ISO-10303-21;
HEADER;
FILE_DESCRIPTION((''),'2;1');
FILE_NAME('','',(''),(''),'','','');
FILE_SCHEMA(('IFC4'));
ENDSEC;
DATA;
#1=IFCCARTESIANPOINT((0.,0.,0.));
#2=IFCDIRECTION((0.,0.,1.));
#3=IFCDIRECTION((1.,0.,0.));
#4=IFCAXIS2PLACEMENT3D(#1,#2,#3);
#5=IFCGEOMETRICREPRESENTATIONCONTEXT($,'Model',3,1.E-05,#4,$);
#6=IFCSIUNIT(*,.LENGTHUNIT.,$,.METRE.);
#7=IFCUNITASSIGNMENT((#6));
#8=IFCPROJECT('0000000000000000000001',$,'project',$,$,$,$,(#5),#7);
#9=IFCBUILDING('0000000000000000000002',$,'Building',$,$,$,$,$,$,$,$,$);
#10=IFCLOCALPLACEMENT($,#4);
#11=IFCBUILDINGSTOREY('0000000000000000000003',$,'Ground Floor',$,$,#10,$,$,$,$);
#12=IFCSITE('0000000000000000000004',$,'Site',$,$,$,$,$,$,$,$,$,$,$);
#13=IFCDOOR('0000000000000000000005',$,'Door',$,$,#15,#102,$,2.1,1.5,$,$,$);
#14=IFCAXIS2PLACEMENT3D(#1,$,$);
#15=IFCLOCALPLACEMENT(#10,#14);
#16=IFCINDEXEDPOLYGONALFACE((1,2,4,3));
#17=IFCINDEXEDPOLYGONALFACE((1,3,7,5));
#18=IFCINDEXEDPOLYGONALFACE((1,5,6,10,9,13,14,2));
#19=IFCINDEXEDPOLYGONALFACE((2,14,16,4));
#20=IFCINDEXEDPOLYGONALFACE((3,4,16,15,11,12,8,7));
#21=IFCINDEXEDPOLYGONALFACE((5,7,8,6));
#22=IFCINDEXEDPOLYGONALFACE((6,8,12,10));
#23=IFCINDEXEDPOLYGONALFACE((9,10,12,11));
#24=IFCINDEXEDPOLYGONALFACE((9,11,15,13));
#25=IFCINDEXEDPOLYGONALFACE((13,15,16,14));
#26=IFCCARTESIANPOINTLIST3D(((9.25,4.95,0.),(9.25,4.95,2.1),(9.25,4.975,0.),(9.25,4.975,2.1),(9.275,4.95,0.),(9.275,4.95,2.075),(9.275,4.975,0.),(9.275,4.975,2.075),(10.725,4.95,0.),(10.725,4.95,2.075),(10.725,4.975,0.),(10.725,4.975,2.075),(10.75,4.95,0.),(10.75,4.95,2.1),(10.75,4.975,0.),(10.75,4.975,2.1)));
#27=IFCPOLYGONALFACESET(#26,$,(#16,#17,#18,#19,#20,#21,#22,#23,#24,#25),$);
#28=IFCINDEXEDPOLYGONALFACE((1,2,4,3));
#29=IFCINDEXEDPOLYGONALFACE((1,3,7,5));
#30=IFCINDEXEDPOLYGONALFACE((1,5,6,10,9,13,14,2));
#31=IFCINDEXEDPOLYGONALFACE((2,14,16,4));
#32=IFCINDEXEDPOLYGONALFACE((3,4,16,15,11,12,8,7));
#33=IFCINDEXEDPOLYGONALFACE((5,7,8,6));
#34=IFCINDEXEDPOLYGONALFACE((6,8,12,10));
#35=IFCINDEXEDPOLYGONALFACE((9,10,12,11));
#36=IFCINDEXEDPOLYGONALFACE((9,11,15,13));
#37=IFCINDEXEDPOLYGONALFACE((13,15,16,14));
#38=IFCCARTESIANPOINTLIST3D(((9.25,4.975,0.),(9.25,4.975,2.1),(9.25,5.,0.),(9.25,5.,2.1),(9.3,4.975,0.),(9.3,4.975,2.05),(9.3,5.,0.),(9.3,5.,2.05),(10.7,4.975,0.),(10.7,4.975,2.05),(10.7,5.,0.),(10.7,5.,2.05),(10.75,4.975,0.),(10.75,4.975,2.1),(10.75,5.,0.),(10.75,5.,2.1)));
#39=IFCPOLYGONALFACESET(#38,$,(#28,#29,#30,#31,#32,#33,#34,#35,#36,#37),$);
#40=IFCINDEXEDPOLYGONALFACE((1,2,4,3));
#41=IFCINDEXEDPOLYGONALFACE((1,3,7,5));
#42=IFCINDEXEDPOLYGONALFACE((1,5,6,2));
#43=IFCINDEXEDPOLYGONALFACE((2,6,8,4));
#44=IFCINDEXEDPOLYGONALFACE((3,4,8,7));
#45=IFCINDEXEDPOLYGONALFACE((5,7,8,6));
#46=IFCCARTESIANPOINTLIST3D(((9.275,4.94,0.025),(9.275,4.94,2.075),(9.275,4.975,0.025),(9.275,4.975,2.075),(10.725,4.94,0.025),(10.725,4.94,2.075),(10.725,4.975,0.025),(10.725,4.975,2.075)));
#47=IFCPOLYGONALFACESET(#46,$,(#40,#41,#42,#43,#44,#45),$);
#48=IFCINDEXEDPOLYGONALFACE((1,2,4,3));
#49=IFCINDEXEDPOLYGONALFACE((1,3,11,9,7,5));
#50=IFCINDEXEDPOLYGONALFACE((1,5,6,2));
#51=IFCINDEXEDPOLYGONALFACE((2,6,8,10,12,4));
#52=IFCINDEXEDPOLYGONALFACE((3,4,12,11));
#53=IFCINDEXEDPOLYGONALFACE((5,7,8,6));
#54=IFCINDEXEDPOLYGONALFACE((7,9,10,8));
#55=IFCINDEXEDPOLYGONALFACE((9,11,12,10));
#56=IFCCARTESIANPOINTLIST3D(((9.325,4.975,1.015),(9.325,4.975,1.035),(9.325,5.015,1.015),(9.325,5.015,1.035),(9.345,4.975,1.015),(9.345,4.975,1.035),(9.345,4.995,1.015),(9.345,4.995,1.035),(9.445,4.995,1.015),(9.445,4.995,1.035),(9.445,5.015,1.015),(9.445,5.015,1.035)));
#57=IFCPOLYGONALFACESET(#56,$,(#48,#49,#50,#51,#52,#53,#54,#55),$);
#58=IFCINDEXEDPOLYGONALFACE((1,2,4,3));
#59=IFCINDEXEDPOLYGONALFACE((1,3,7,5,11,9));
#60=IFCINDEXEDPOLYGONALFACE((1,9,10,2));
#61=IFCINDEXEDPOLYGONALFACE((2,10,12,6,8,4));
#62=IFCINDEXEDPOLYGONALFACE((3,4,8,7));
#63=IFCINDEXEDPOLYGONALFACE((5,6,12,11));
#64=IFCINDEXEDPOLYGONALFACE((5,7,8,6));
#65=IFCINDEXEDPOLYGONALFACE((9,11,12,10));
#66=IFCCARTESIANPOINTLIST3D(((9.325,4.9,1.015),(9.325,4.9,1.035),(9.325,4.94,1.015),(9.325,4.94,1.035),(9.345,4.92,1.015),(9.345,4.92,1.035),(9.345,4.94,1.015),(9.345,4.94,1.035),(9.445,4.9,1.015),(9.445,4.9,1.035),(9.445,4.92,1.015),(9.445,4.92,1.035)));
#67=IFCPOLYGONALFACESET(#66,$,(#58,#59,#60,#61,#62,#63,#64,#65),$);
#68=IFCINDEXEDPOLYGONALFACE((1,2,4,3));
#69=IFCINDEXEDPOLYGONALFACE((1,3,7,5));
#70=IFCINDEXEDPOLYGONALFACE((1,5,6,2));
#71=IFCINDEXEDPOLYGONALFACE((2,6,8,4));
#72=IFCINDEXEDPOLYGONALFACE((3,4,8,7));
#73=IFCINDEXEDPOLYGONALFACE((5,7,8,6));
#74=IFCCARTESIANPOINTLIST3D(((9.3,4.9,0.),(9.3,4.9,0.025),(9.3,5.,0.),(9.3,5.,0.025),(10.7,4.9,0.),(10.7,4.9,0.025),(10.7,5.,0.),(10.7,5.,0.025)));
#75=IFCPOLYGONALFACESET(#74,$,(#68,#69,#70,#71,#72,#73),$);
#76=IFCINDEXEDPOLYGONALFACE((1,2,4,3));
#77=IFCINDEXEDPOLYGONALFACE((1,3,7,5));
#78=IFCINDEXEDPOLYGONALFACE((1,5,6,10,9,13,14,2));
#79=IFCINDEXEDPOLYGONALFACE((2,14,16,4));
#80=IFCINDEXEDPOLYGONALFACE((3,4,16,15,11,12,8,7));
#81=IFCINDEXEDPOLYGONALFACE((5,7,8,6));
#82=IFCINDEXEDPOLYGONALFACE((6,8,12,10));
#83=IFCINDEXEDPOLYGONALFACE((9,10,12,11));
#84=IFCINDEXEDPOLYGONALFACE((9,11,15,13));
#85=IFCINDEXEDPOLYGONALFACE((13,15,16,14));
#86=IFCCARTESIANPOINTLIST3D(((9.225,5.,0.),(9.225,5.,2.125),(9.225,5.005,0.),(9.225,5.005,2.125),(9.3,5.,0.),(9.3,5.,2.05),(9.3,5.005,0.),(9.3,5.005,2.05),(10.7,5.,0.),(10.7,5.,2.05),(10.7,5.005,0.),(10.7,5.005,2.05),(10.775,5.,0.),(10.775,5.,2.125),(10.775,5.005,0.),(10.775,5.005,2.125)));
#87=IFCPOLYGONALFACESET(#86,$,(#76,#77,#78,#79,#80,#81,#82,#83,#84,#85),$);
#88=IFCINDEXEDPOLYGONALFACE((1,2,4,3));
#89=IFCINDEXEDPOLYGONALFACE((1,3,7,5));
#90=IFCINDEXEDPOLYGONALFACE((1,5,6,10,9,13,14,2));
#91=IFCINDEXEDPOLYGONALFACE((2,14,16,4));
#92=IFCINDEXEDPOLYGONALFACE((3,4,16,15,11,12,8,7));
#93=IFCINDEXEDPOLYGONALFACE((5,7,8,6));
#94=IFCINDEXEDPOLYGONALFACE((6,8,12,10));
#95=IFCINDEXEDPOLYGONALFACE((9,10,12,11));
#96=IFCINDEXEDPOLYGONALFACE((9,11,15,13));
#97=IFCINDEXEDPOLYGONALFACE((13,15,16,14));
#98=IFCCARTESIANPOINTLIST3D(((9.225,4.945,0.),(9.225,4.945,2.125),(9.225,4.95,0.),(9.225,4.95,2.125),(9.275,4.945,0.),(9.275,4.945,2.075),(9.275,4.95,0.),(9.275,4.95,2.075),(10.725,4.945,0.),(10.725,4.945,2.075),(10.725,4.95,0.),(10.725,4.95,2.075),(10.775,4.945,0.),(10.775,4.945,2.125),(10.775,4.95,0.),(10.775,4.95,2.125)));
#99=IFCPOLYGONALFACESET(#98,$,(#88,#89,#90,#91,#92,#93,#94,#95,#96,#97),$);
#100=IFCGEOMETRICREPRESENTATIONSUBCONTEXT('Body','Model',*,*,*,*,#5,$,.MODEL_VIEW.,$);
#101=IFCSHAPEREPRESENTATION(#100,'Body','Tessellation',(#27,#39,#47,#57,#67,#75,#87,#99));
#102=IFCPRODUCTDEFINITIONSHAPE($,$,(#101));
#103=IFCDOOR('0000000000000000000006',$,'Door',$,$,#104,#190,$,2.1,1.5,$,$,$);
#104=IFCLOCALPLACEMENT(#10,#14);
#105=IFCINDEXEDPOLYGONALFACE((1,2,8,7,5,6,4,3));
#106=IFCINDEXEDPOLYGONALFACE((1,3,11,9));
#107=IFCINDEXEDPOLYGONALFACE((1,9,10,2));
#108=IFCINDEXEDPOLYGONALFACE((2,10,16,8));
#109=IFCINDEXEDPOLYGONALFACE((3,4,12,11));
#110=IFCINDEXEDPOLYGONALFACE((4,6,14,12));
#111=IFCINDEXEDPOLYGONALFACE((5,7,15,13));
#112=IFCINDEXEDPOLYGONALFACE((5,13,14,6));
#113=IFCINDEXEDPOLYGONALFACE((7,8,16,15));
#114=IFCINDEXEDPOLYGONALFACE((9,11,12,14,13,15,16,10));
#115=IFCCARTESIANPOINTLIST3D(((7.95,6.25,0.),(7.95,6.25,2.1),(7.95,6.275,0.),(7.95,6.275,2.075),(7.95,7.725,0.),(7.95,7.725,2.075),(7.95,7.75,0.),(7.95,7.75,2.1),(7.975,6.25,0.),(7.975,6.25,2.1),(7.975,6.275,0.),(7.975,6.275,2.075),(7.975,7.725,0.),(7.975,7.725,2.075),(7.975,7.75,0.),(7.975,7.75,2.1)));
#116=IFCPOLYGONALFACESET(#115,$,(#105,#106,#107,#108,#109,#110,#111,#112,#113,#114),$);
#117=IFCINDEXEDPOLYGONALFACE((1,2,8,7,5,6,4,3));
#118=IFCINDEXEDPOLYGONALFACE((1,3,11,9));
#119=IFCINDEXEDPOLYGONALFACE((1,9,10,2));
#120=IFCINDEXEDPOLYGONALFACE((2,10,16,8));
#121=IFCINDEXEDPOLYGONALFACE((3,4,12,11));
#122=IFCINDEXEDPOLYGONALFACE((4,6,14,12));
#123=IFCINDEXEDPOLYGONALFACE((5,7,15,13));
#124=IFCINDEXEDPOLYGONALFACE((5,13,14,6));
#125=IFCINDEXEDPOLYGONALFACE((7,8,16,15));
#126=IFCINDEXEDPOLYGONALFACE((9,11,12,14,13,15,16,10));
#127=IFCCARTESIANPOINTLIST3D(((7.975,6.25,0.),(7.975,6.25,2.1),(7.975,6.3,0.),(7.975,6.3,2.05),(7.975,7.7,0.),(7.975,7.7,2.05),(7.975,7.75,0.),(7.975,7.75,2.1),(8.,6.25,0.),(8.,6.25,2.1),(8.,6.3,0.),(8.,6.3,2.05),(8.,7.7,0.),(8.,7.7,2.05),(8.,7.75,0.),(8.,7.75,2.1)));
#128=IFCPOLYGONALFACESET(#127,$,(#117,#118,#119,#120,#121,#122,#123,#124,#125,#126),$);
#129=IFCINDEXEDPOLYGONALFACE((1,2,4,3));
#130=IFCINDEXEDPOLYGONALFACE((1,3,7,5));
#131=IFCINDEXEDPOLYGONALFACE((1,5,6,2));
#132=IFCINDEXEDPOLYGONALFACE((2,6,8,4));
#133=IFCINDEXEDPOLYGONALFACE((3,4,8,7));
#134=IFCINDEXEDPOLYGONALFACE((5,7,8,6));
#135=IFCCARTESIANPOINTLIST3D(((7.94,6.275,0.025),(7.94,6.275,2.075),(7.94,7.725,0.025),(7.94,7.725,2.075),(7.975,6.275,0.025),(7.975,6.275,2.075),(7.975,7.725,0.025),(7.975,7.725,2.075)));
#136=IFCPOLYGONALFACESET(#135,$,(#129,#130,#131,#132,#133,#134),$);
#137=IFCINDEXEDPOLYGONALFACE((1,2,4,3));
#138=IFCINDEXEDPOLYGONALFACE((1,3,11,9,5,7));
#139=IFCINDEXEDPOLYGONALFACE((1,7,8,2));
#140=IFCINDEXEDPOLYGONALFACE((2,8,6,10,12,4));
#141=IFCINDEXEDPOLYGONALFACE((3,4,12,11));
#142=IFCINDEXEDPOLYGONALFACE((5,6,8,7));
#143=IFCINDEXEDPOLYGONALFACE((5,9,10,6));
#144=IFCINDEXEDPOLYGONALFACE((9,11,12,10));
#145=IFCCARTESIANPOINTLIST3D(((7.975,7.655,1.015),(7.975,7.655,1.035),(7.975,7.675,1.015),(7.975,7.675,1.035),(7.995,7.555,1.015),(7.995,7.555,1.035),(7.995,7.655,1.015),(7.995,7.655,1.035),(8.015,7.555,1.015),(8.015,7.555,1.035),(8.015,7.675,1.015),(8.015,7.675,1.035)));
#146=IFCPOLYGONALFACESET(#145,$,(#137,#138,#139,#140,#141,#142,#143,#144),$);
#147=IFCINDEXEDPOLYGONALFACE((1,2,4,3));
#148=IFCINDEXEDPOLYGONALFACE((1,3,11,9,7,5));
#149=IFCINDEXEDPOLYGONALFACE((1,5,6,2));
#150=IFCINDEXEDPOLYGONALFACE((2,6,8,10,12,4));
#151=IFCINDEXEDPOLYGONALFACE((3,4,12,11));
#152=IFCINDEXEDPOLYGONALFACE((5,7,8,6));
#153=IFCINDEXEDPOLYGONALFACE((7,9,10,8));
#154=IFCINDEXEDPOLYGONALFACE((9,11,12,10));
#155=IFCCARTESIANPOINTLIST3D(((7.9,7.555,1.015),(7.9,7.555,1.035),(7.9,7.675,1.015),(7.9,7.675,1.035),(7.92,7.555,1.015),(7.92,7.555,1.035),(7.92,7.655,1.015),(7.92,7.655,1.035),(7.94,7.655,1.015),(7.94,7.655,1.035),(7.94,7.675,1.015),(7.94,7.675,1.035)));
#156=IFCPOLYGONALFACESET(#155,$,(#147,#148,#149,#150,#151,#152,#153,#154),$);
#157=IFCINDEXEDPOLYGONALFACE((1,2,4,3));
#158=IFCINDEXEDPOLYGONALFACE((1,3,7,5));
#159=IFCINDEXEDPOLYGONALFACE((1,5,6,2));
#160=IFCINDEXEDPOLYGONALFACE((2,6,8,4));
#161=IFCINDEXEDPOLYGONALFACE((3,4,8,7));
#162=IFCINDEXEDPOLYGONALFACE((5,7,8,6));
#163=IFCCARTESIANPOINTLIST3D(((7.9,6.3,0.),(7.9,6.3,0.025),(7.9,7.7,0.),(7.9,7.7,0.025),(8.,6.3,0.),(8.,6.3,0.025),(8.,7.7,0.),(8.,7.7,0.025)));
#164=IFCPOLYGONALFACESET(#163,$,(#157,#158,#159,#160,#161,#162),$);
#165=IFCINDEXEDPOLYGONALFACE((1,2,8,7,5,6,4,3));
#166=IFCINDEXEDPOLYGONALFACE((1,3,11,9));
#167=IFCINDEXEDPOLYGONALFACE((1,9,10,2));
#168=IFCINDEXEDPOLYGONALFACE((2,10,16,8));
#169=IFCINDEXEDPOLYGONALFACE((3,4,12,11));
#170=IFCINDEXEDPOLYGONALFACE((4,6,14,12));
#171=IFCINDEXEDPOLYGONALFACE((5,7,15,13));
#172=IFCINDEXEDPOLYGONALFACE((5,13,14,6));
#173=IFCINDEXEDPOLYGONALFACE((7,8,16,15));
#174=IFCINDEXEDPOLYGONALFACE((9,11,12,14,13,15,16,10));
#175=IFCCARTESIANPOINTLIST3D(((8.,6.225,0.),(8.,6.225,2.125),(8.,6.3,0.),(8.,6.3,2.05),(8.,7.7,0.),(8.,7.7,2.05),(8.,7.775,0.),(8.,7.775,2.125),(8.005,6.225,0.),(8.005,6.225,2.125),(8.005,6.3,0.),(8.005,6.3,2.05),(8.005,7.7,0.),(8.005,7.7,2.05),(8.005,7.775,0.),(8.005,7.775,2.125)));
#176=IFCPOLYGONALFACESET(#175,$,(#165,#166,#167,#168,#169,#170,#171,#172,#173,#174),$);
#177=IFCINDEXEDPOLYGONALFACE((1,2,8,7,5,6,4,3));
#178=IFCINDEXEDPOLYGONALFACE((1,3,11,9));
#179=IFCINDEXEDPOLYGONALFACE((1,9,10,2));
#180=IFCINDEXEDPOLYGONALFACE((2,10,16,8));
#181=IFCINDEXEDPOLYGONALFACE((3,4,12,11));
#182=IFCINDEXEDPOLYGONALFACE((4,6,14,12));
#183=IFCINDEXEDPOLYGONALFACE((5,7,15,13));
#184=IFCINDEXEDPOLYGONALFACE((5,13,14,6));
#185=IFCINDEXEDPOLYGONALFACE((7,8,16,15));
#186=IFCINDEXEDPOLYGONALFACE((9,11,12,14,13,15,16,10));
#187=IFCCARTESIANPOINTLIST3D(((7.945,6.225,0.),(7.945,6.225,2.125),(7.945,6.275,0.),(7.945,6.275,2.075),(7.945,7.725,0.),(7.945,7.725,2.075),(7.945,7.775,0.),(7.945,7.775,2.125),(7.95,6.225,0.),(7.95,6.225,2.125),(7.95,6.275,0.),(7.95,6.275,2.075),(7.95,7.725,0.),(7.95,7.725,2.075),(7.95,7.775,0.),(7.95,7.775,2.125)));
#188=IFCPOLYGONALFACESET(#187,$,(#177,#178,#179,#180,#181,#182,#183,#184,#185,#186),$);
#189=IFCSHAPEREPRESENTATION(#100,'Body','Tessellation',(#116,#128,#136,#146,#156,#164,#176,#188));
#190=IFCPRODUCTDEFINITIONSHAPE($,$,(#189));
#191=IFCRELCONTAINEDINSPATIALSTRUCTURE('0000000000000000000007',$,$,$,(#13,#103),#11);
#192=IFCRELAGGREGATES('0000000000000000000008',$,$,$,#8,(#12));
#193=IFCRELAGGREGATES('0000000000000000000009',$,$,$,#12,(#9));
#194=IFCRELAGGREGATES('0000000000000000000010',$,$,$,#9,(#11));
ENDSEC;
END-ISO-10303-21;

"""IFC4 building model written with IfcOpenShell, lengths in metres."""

from ifc_helpers import new_model, si_unit, frame, origin_with_axes, place, context, subcontext, project, spatial, line, indexed_curve, outline, extrude, element, save


model = new_model("IFC4")

# Units and contexts
model_context = context("Model", 3, precision=1e-05, world=origin_with_axes())
body_context = subcontext(model_context, "Body", "Model", "MODEL_VIEW")
ifc_project = project(units=[si_unit("LENGTHUNIT", "METRE")], contexts=[model_context])

# Site, building, storey
site = spatial("IfcSite", under=ifc_project, Name="Site")
building = spatial("IfcBuilding", under=site, Name="Building")
storey_placement = place(None, origin_with_axes())
storey = spatial("IfcBuildingStorey", under=building, at=storey_placement, Name="Ground Floor")

# Doors
door_1_placement = place(storey_placement, frame((10.75, 5.0, 0.0), z_axis=(0.0, 0.0, 1.0), x_axis=(-1.0, 0.0, 0.0)))
element("IfcDoor", 1, at=door_1_placement, inside=storey, Name="Door", OverallHeight=2.1, OverallWidth=1.5, context=body_context, shape_type="SweptSolid", body=[
    extrude(outline(indexed_curve([(0.0, 0.0), (0.0, 2.1), (1.5, 2.1), (1.5, 0.0), (1.475, 0.0), (1.475, 2.075), (0.025, 2.075), (0.025, 0.0)], segments=[line(1, 2, 3, 4, 5, 6, 7, 8, 1)])), frame((0.0, 0.025, 0.0), z_axis=(0.0, -1.0, 0.0), x_axis=(1.0, 0.0, 0.0)), (0.0, 0.0, -1.0), 0.025),
    extrude(outline(indexed_curve([(0.0, 0.0), (0.0, 2.1), (1.5, 2.1), (1.5, 0.0), (1.45, 0.0), (1.45, 2.05), (0.05, 2.05), (0.05, 0.0)], segments=[line(1, 2, 3, 4, 5, 6, 7, 8, 1)])), frame((0.0, 0.0, 0.0), z_axis=(0.0, -1.0, 0.0), x_axis=(1.0, 0.0, 0.0)), (0.0, 0.0, -1.0), 0.025),
    extrude(outline(indexed_curve([(0.0, 0.0), (1.45, 0.0), (1.45, 0.035), (0.0, 0.035)], segments=[line(1, 2, 3, 4, 1)])), frame((0.025, 0.025, 0.025), z_axis=(0.0, 0.0, 1.0), x_axis=(1.0, 0.0, 0.0)), (0.0, 0.0, 1.0), 2.05),
    extrude(outline(indexed_curve([(0.0, 0.0), (0.0, -0.04), (-0.12, -0.04), (-0.12, -0.02), (-0.02, -0.02), (-0.02, 0.0)], segments=[line(1, 2, 3, 4, 5, 6, 1)])), frame((1.425, 0.025, 1.015), z_axis=(0.0, 0.0, 1.0), x_axis=(1.0, 0.0, 0.0)), (0.0, 0.0, 1.0), 0.02),
    extrude(outline(indexed_curve([(0.0, 0.0), (0.0, 0.04), (-0.12, 0.04), (-0.12, 0.02), (-0.02, 0.02), (-0.02, 0.0)], segments=[line(1, 2, 3, 4, 5, 6, 1)])), frame((1.425, 0.06, 1.015), z_axis=(0.0, 0.0, 1.0), x_axis=(1.0, 0.0, 0.0)), (0.0, 0.0, 1.0), 0.02),
    extrude(outline(indexed_curve([(0.0, 0.0), (1.4, 0.0), (1.4, 0.1), (0.0, 0.1)], segments=[line(1, 2, 3, 4, 1)])), frame((0.05, 0.0, 0.0), z_axis=(0.0, 0.0, 1.0), x_axis=(1.0, 0.0, 0.0)), (0.0, 0.0, 1.0), 0.025),
    extrude(outline(indexed_curve([(0.0, 0.0), (0.0, 2.125), (1.55, 2.125), (1.55, 0.0), (1.475, 0.0), (1.475, 2.05), (0.075, 2.05), (0.075, 0.0)], segments=[line(1, 2, 3, 4, 5, 6, 7, 8, 1)])), frame((-0.025, -0.005, 0.0), z_axis=(0.0, -1.0, 0.0), x_axis=(1.0, 0.0, 0.0)), (0.0, 0.0, -1.0), 0.005),
    extrude(outline(indexed_curve([(0.0, 0.0), (0.0, 2.125), (1.55, 2.125), (1.55, 0.0), (1.5, 0.0), (1.5, 2.075), (0.05, 2.075), (0.05, 0.0)], segments=[line(1, 2, 3, 4, 5, 6, 7, 8, 1)])), frame((-0.025, 0.05, 0.0), z_axis=(0.0, -1.0, 0.0), x_axis=(1.0, 0.0, 0.0)), (0.0, 0.0, -1.0), 0.005),
])
door_2_placement = place(storey_placement, frame((8.0, 6.25, 0.0), z_axis=(0.0, 0.0, 1.0), x_axis=(0.0, 1.0, 0.0)))
element("IfcDoor", 2, at=door_2_placement, inside=storey, Name="Door", OverallHeight=2.1, OverallWidth=1.5, context=body_context, shape_type="SweptSolid", body=[
    extrude(outline(indexed_curve([(0.0, 0.0), (0.0, 2.1), (1.5, 2.1), (1.5, 0.0), (1.475, 0.0), (1.475, 2.075), (0.025, 2.075), (0.025, 0.0)], segments=[line(1, 2, 3, 4, 5, 6, 7, 8, 1)])), frame((0.0, 0.025, 0.0), z_axis=(0.0, -1.0, 0.0), x_axis=(1.0, 0.0, 0.0)), (0.0, 0.0, -1.0), 0.025),
    extrude(outline(indexed_curve([(0.0, 0.0), (0.0, 2.1), (1.5, 2.1), (1.5, 0.0), (1.45, 0.0), (1.45, 2.05), (0.05, 2.05), (0.05, 0.0)], segments=[line(1, 2, 3, 4, 5, 6, 7, 8, 1)])), frame((0.0, 0.0, 0.0), z_axis=(0.0, -1.0, 0.0), x_axis=(1.0, 0.0, 0.0)), (0.0, 0.0, -1.0), 0.025),
    extrude(outline(indexed_curve([(0.0, 0.0), (1.45, 0.0), (1.45, 0.035), (0.0, 0.035)], segments=[line(1, 2, 3, 4, 1)])), frame((0.025, 0.025, 0.025), z_axis=(0.0, 0.0, 1.0), x_axis=(1.0, 0.0, 0.0)), (0.0, 0.0, 1.0), 2.05),
    extrude(outline(indexed_curve([(0.0, 0.0), (0.0, -0.04), (-0.12, -0.04), (-0.12, -0.02), (-0.02, -0.02), (-0.02, 0.0)], segments=[line(1, 2, 3, 4, 5, 6, 1)])), frame((1.425, 0.025, 1.015), z_axis=(0.0, 0.0, 1.0), x_axis=(1.0, 0.0, 0.0)), (0.0, 0.0, 1.0), 0.02),
    extrude(outline(indexed_curve([(0.0, 0.0), (0.0, 0.04), (-0.12, 0.04), (-0.12, 0.02), (-0.02, 0.02), (-0.02, 0.0)], segments=[line(1, 2, 3, 4, 5, 6, 1)])), frame((1.425, 0.06, 1.015), z_axis=(0.0, 0.0, 1.0), x_axis=(1.0, 0.0, 0.0)), (0.0, 0.0, 1.0), 0.02),
    extrude(outline(indexed_curve([(0.0, 0.0), (1.4, 0.0), (1.4, 0.1), (0.0, 0.1)], segments=[line(1, 2, 3, 4, 1)])), frame((0.05, 0.0, 0.0), z_axis=(0.0, 0.0, 1.0), x_axis=(1.0, 0.0, 0.0)), (0.0, 0.0, 1.0), 0.025),
    extrude(outline(indexed_curve([(0.0, 0.0), (0.0, 2.125), (1.55, 2.125), (1.55, 0.0), (1.475, 0.0), (1.475, 2.05), (0.075, 2.05), (0.075, 0.0)], segments=[line(1, 2, 3, 4, 5, 6, 7, 8, 1)])), frame((-0.025, -0.005, 0.0), z_axis=(0.0, -1.0, 0.0), x_axis=(1.0, 0.0, 0.0)), (0.0, 0.0, -1.0), 0.005),
    extrude(outline(indexed_curve([(0.0, 0.0), (0.0, 2.125), (1.55, 2.125), (1.55, 0.0), (1.5, 0.0), (1.5, 2.075), (0.05, 2.075), (0.05, 0.0)], segments=[line(1, 2, 3, 4, 5, 6, 7, 8, 1)])), frame((-0.025, 0.05, 0.0), z_axis=(0.0, -1.0, 0.0), x_axis=(1.0, 0.0, 0.0)), (0.0, 0.0, -1.0), 0.005),
])

save(model, "model.ifc")
